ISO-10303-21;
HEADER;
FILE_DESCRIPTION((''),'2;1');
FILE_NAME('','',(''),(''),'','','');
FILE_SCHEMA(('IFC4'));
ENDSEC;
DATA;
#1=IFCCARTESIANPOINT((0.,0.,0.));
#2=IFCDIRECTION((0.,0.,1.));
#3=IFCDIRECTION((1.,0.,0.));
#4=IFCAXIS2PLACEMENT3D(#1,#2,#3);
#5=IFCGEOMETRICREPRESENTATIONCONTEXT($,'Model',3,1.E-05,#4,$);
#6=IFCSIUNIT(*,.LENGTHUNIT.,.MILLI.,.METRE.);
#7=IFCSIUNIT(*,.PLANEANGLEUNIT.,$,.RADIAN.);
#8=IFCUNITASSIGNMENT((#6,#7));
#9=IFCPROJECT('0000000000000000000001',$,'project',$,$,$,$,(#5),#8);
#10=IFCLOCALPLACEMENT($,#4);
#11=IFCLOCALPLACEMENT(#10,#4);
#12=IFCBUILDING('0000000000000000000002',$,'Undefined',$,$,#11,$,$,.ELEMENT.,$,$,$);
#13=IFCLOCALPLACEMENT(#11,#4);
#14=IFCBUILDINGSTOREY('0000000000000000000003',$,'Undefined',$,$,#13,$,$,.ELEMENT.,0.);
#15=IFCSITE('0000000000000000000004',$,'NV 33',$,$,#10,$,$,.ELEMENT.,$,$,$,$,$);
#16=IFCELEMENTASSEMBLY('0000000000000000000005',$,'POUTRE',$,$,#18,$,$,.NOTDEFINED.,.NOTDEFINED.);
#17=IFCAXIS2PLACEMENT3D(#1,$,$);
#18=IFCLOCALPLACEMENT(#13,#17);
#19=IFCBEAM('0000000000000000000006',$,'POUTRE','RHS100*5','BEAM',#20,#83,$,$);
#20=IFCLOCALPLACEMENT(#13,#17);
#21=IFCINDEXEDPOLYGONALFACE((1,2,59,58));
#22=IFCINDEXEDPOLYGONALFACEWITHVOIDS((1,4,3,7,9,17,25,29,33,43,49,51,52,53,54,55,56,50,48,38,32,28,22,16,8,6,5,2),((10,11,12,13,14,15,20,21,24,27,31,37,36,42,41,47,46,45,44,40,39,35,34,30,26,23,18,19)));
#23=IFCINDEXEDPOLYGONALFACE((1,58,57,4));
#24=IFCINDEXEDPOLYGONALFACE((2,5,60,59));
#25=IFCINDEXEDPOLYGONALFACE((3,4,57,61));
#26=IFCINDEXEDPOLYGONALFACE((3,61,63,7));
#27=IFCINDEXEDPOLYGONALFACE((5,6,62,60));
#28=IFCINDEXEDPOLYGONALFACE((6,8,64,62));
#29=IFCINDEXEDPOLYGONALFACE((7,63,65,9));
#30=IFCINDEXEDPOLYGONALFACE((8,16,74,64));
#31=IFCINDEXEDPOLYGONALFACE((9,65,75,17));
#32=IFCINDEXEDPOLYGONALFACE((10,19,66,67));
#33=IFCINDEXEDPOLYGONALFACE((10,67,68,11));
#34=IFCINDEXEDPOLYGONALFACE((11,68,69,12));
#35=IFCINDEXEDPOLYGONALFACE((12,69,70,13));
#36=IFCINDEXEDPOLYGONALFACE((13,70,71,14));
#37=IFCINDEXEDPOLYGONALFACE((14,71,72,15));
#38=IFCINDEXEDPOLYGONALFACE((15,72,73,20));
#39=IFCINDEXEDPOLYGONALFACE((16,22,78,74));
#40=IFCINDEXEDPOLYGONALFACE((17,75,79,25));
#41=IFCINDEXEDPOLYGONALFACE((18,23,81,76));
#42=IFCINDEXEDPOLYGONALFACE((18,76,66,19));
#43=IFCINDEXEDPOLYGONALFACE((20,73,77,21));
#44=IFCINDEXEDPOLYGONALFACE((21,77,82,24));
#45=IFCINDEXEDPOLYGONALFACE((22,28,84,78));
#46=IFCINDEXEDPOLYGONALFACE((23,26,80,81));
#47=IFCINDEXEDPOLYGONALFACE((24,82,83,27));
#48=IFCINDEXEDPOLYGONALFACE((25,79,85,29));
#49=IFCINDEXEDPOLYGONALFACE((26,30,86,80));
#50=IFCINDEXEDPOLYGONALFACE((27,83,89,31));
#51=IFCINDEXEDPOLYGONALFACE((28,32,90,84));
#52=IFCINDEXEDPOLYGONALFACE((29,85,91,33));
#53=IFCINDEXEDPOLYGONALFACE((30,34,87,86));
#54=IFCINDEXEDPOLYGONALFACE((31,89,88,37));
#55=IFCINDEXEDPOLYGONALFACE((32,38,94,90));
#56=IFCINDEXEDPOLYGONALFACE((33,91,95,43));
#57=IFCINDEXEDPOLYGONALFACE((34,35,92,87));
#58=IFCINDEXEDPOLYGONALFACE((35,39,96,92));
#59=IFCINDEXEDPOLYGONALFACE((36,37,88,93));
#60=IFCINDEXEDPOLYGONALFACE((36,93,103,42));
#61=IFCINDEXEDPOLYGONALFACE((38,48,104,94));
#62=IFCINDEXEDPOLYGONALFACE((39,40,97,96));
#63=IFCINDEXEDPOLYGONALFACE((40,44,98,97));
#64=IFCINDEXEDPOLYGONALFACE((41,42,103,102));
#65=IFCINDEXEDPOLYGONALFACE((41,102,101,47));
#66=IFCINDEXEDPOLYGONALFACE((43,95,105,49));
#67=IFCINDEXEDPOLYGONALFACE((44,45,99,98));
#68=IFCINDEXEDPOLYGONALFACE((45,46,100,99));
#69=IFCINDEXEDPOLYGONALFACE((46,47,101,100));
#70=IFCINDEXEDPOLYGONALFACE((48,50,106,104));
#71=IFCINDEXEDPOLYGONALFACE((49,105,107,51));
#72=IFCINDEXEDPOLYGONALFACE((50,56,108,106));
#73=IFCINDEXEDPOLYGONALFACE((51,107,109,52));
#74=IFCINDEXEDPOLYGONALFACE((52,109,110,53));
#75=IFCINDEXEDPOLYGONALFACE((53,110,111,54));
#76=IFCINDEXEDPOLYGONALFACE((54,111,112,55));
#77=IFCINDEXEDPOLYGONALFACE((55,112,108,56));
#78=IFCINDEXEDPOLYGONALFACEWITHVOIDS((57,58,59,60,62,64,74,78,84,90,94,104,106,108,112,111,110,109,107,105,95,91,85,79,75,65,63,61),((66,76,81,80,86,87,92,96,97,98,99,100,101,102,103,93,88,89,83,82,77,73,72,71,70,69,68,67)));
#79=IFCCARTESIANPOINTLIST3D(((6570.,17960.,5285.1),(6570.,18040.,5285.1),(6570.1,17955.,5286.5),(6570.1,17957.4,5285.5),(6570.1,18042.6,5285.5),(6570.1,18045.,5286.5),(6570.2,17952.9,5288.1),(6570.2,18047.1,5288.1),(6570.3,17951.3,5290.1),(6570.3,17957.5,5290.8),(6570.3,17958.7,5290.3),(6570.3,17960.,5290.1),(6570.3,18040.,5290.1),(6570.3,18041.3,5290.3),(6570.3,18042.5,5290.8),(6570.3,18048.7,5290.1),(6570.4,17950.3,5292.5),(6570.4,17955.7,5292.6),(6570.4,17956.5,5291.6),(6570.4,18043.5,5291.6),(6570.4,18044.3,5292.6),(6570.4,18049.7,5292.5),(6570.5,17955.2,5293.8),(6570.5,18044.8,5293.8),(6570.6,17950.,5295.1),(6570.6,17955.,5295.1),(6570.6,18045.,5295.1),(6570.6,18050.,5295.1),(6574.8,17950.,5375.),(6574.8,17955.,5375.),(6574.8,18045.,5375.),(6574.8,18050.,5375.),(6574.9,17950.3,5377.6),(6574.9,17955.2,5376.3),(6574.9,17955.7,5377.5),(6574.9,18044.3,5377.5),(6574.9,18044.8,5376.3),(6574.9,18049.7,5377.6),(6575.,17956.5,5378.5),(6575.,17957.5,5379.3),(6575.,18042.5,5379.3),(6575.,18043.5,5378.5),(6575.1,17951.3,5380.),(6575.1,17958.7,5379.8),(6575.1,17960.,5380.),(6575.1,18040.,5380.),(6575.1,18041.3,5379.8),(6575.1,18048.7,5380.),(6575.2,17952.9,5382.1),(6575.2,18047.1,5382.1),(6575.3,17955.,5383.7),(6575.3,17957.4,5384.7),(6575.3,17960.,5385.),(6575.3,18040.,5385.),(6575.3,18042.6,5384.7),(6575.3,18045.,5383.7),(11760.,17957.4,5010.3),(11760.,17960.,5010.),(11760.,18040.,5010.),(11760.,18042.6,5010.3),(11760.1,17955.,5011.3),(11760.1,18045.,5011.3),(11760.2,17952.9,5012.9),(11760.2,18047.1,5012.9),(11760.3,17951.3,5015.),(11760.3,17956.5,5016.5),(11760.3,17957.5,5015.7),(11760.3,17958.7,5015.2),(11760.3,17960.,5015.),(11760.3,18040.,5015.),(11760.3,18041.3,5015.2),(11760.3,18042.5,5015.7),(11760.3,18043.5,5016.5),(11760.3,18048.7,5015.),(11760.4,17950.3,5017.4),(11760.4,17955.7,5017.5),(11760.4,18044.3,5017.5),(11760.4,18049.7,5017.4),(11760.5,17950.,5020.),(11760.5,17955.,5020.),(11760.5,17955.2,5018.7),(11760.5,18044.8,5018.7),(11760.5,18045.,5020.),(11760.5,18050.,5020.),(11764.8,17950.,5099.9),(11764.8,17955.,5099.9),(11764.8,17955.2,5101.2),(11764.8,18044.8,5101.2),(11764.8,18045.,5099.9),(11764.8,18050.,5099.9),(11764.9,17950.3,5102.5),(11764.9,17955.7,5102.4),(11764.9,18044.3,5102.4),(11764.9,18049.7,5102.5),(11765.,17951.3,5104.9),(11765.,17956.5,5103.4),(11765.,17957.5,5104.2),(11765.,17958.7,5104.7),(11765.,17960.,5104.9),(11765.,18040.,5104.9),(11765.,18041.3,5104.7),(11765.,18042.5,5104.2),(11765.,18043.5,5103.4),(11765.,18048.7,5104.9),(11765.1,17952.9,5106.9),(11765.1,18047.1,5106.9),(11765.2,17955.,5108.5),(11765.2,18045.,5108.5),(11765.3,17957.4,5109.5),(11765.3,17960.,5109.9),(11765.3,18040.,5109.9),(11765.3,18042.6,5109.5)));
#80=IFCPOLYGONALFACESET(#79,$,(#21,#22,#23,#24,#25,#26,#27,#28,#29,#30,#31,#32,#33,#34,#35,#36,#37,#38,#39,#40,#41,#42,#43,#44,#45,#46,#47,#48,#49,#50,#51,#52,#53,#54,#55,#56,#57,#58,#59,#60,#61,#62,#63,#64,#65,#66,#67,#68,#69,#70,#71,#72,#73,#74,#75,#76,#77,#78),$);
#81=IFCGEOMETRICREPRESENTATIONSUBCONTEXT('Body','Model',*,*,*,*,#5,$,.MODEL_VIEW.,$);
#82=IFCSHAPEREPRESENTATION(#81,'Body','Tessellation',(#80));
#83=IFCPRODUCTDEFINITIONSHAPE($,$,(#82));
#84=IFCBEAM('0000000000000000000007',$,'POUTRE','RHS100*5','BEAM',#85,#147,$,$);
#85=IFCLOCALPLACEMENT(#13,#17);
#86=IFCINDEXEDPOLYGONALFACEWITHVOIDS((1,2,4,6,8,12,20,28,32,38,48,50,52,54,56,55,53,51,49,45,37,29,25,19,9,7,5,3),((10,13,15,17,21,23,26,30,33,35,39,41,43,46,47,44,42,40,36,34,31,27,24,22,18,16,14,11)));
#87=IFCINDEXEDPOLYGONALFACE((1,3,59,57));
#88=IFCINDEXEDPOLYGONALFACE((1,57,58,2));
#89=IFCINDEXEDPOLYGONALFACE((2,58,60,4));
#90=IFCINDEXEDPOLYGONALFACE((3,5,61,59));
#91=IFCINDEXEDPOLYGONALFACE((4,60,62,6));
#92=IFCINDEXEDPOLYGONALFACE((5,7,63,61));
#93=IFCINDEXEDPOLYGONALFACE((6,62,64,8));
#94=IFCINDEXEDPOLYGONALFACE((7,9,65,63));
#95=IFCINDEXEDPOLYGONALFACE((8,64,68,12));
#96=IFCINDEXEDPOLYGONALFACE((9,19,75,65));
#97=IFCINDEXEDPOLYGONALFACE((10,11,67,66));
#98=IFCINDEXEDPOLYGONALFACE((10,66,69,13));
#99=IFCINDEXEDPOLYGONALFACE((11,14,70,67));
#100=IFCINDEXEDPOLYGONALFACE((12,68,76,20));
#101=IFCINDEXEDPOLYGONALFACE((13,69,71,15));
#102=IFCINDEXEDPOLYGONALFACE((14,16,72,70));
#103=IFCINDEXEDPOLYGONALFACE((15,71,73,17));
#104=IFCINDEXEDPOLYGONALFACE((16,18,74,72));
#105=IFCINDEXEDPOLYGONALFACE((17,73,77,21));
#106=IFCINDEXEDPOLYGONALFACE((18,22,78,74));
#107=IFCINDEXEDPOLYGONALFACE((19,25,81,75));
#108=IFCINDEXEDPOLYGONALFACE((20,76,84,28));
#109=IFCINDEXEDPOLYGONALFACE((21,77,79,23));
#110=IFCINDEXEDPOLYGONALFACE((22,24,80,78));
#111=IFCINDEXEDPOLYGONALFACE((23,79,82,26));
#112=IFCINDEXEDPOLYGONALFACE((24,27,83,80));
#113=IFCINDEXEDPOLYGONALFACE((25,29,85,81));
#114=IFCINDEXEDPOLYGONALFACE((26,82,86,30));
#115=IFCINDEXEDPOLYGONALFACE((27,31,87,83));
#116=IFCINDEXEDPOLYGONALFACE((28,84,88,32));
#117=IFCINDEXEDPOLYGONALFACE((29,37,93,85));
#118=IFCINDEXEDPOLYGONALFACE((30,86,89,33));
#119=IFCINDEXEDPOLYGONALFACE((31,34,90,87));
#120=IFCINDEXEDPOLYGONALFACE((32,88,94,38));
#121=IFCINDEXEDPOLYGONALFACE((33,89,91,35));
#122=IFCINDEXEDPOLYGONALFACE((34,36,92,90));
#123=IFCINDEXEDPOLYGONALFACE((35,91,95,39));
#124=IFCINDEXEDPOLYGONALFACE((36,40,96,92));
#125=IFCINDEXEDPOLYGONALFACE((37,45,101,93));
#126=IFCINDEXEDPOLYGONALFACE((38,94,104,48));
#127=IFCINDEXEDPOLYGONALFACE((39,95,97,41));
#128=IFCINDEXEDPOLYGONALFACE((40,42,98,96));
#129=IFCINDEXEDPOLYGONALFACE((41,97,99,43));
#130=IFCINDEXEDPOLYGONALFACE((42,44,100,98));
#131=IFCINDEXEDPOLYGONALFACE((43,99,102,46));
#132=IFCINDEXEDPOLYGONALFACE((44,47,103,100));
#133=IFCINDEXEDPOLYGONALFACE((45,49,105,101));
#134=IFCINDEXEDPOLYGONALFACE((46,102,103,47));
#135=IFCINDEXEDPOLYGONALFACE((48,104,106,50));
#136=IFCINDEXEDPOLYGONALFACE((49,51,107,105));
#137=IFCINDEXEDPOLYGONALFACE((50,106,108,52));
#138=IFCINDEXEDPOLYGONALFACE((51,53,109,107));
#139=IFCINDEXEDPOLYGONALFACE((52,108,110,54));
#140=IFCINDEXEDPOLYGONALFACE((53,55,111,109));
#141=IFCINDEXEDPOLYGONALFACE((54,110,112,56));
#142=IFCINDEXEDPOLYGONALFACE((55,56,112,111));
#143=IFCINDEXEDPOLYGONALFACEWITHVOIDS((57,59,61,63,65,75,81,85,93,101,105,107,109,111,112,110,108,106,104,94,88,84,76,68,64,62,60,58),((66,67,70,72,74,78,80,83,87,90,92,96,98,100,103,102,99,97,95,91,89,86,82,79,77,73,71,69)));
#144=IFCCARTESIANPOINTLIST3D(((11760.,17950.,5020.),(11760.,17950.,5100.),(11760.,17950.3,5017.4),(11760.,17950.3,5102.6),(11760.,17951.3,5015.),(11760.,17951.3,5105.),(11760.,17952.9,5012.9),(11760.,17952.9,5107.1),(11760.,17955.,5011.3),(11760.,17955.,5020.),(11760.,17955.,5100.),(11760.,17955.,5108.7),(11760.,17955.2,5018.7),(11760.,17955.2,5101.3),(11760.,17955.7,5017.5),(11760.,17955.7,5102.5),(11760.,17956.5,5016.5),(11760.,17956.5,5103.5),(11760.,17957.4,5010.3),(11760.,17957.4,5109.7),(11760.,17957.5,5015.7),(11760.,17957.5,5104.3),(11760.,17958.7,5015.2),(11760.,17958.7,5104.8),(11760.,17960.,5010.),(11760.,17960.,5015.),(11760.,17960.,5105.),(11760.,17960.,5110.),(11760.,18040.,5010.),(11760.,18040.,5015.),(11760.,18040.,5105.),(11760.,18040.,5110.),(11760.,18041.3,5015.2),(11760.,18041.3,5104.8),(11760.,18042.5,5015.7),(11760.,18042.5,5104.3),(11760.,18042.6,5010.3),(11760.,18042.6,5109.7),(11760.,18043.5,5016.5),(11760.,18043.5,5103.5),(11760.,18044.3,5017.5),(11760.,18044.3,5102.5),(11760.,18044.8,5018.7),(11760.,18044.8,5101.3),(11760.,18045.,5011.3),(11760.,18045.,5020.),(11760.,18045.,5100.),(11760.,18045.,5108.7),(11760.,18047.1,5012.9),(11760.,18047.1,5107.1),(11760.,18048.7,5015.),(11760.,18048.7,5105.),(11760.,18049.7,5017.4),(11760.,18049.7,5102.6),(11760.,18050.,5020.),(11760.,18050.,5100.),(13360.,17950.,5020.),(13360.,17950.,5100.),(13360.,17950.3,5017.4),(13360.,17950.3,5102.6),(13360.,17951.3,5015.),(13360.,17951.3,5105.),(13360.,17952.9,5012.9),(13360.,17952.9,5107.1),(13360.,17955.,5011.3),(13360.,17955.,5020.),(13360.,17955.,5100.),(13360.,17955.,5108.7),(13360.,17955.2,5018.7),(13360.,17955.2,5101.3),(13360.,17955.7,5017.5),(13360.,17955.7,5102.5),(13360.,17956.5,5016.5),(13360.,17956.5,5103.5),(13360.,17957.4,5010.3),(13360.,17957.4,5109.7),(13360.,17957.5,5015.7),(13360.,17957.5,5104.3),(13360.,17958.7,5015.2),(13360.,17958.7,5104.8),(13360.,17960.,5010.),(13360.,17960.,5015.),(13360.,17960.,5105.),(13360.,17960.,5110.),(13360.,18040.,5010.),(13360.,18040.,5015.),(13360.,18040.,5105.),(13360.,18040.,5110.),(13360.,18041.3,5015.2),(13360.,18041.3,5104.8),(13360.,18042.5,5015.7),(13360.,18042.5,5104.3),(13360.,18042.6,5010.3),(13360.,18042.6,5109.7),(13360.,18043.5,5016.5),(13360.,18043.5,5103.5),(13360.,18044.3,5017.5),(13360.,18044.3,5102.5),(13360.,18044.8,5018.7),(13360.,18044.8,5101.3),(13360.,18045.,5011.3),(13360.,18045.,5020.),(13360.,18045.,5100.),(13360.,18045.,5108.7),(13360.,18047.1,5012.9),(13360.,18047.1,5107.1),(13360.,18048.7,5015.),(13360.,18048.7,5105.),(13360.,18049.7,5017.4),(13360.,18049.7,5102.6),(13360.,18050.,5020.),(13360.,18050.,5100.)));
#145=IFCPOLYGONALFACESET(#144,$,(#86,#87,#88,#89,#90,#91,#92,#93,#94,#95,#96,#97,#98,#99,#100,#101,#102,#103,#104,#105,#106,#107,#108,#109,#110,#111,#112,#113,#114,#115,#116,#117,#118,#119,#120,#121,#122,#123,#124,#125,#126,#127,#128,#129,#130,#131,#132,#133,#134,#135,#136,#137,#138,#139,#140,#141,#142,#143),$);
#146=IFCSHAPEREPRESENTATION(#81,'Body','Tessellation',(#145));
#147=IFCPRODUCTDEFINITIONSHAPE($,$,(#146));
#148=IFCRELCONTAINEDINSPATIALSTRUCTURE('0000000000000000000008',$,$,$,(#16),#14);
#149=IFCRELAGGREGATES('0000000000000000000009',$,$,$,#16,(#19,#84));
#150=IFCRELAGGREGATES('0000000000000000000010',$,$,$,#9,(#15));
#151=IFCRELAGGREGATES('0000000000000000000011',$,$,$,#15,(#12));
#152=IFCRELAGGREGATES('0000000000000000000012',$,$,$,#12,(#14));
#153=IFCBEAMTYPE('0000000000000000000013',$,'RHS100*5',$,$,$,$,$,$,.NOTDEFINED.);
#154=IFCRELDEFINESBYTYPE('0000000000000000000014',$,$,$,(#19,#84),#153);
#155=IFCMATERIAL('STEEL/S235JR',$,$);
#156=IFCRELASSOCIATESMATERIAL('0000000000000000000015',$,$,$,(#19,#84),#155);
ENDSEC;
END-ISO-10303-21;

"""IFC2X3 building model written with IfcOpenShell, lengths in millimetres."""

from ifc_helpers import new_model, si_unit, frame, origin_with_axes, origin_2d_with_axis, place, context, subcontext, project, spatial, hollow_rectangle, extrude, boolean, halfspace, material, type_object, element, aggregate, save


model = new_model("IFC2X3")

# Units and contexts
model_context = context("Model", 3, precision=1e-05, world=origin_with_axes())
body_context = subcontext(model_context, "Body", "Model", "MODEL_VIEW")
ifc_project = project(units=[si_unit("LENGTHUNIT", "METRE", prefix="MILLI"), si_unit("PLANEANGLEUNIT", "RADIAN")], contexts=[model_context])

# Site, building, storey
site_placement = place(None, origin_with_axes())
site = spatial("IfcSite", under=ifc_project, at=site_placement, Name="NV 33", CompositionType="ELEMENT")
building_placement = place(site_placement, origin_with_axes())
building = spatial("IfcBuilding", under=site, at=building_placement, Name="Undefined", CompositionType="ELEMENT")
storey_placement = place(building_placement, origin_with_axes())
storey = spatial("IfcBuildingStorey", under=building, at=storey_placement, Name="Undefined", CompositionType="ELEMENT", Elevation=0.0)

# Shared definitions
ifc_material_1 = material(Name="STEEL/S235JR")

# Shared definitions
beam_type_1 = type_object("IfcBeamType", Name="RHS100*5", PredefinedType="NOTDEFINED")

# Element assembly, beams
assembly_1_placement = place(storey_placement, origin_with_axes())
assembly_1 = element("IfcElementAssembly", 1, at=assembly_1_placement, inside=storey, Name="POUTRE", AssemblyPlace="NOTDEFINED", PredefinedType="NOTDEFINED")
beam_1_placement = place(assembly_1_placement, frame((11762.6, 18000.0, 5059.9), z_axis=(-0.052941, 0.0, -0.998598), x_axis=(-0.998598, 0.0, 0.052941)))
solid_1 = boolean("DIFFERENCE", boolean("DIFFERENCE", extrude(hollow_rectangle(XDim=100.0, YDim=100.0, WallThickness=5.0, InnerFilletRadius=5.0, OuterFilletRadius=10.0, at=origin_2d_with_axis()), frame((5142.7, 0.0, -2.9), z_axis=(0.994395, 0.0, 0.105733), x_axis=(0.0, 1.0, 0.0)), (0.0, 0.0, 1.0), 5197.2), extrude(hollow_rectangle(XDim=100.0, YDim=100.0, WallThickness=5.0, InnerFilletRadius=5.0, OuterFilletRadius=10.0, at=origin_2d_with_axis()), frame((10308.2, 0.0, 546.4), z_axis=(0.998598, 0.0, 0.052941), x_axis=(-0.052941, 0.0, 0.998598)), (0.0, 0.0, 1.0), 1600.0)), halfspace(frame((5172.5, 50.0, -50.0), z_axis=(-0.998598, 0.0, -0.052941), x_axis=(-0.052941, 0.0, 0.998598)), False))
beam_1 = element("IfcBeam", 2, at=beam_1_placement, type_object=beam_type_1, material=ifc_material_1, Name="POUTRE", Description="RHS100*5", ObjectType="BEAM", context=body_context, shape_type="CSG", body=[
    boolean("DIFFERENCE", boolean("DIFFERENCE", boolean("DIFFERENCE", extrude(hollow_rectangle(XDim=100.0, YDim=100.0, WallThickness=5.0, InnerFilletRadius=5.0, OuterFilletRadius=10.0, at=origin_2d_with_axis()), frame((5197.2, 0.0, 0.0), z_axis=(-1.0, 0.0, 0.0), x_axis=(0.0, -1.0, 0.0)), (0.0, 0.0, 1.0), 5197.2), solid_1), extrude(hollow_rectangle(XDim=100.0, YDim=100.0, WallThickness=5.0, InnerFilletRadius=5.0, OuterFilletRadius=10.0, at=origin_2d_with_axis()), frame((2.6, 0.0, 0.1), z_axis=(-0.998598, 0.0, -0.052941), x_axis=(0.052941, 0.0, -0.998598)), (0.0, 0.0, 1.0), 1600.0)), halfspace(frame((5172.5, 50.0, -50.0), z_axis=(0.998598, 0.0, 0.052941), x_axis=(0.0, -1.0, 0.0)), False)),
])
beam_2_placement = place(assembly_1_placement, frame((13360.0, 18000.0, 5060.0), z_axis=(0.0, -1.0, 0.0), x_axis=(-1.0, 0.0, 0.0)))
beam_2 = element("IfcBeam", 3, at=beam_2_placement, type_object=beam_type_1, material=ifc_material_1, Name="POUTRE", Description="RHS100*5", ObjectType="BEAM", context=body_context, shape_type="SweptSolid", body=[
    extrude(hollow_rectangle(XDim=100.0, YDim=100.0, WallThickness=5.0, InnerFilletRadius=5.0, OuterFilletRadius=10.0, at=origin_2d_with_axis()), frame((1600.0, 0.0, 0.0), z_axis=(-1.0, 0.0, 0.0), x_axis=(0.0, -1.0, 0.0)), (0.0, 0.0, 1.0), 1600.0),
])
aggregate(assembly_1, [beam_1, beam_2])

save(model, "model.ifc")
